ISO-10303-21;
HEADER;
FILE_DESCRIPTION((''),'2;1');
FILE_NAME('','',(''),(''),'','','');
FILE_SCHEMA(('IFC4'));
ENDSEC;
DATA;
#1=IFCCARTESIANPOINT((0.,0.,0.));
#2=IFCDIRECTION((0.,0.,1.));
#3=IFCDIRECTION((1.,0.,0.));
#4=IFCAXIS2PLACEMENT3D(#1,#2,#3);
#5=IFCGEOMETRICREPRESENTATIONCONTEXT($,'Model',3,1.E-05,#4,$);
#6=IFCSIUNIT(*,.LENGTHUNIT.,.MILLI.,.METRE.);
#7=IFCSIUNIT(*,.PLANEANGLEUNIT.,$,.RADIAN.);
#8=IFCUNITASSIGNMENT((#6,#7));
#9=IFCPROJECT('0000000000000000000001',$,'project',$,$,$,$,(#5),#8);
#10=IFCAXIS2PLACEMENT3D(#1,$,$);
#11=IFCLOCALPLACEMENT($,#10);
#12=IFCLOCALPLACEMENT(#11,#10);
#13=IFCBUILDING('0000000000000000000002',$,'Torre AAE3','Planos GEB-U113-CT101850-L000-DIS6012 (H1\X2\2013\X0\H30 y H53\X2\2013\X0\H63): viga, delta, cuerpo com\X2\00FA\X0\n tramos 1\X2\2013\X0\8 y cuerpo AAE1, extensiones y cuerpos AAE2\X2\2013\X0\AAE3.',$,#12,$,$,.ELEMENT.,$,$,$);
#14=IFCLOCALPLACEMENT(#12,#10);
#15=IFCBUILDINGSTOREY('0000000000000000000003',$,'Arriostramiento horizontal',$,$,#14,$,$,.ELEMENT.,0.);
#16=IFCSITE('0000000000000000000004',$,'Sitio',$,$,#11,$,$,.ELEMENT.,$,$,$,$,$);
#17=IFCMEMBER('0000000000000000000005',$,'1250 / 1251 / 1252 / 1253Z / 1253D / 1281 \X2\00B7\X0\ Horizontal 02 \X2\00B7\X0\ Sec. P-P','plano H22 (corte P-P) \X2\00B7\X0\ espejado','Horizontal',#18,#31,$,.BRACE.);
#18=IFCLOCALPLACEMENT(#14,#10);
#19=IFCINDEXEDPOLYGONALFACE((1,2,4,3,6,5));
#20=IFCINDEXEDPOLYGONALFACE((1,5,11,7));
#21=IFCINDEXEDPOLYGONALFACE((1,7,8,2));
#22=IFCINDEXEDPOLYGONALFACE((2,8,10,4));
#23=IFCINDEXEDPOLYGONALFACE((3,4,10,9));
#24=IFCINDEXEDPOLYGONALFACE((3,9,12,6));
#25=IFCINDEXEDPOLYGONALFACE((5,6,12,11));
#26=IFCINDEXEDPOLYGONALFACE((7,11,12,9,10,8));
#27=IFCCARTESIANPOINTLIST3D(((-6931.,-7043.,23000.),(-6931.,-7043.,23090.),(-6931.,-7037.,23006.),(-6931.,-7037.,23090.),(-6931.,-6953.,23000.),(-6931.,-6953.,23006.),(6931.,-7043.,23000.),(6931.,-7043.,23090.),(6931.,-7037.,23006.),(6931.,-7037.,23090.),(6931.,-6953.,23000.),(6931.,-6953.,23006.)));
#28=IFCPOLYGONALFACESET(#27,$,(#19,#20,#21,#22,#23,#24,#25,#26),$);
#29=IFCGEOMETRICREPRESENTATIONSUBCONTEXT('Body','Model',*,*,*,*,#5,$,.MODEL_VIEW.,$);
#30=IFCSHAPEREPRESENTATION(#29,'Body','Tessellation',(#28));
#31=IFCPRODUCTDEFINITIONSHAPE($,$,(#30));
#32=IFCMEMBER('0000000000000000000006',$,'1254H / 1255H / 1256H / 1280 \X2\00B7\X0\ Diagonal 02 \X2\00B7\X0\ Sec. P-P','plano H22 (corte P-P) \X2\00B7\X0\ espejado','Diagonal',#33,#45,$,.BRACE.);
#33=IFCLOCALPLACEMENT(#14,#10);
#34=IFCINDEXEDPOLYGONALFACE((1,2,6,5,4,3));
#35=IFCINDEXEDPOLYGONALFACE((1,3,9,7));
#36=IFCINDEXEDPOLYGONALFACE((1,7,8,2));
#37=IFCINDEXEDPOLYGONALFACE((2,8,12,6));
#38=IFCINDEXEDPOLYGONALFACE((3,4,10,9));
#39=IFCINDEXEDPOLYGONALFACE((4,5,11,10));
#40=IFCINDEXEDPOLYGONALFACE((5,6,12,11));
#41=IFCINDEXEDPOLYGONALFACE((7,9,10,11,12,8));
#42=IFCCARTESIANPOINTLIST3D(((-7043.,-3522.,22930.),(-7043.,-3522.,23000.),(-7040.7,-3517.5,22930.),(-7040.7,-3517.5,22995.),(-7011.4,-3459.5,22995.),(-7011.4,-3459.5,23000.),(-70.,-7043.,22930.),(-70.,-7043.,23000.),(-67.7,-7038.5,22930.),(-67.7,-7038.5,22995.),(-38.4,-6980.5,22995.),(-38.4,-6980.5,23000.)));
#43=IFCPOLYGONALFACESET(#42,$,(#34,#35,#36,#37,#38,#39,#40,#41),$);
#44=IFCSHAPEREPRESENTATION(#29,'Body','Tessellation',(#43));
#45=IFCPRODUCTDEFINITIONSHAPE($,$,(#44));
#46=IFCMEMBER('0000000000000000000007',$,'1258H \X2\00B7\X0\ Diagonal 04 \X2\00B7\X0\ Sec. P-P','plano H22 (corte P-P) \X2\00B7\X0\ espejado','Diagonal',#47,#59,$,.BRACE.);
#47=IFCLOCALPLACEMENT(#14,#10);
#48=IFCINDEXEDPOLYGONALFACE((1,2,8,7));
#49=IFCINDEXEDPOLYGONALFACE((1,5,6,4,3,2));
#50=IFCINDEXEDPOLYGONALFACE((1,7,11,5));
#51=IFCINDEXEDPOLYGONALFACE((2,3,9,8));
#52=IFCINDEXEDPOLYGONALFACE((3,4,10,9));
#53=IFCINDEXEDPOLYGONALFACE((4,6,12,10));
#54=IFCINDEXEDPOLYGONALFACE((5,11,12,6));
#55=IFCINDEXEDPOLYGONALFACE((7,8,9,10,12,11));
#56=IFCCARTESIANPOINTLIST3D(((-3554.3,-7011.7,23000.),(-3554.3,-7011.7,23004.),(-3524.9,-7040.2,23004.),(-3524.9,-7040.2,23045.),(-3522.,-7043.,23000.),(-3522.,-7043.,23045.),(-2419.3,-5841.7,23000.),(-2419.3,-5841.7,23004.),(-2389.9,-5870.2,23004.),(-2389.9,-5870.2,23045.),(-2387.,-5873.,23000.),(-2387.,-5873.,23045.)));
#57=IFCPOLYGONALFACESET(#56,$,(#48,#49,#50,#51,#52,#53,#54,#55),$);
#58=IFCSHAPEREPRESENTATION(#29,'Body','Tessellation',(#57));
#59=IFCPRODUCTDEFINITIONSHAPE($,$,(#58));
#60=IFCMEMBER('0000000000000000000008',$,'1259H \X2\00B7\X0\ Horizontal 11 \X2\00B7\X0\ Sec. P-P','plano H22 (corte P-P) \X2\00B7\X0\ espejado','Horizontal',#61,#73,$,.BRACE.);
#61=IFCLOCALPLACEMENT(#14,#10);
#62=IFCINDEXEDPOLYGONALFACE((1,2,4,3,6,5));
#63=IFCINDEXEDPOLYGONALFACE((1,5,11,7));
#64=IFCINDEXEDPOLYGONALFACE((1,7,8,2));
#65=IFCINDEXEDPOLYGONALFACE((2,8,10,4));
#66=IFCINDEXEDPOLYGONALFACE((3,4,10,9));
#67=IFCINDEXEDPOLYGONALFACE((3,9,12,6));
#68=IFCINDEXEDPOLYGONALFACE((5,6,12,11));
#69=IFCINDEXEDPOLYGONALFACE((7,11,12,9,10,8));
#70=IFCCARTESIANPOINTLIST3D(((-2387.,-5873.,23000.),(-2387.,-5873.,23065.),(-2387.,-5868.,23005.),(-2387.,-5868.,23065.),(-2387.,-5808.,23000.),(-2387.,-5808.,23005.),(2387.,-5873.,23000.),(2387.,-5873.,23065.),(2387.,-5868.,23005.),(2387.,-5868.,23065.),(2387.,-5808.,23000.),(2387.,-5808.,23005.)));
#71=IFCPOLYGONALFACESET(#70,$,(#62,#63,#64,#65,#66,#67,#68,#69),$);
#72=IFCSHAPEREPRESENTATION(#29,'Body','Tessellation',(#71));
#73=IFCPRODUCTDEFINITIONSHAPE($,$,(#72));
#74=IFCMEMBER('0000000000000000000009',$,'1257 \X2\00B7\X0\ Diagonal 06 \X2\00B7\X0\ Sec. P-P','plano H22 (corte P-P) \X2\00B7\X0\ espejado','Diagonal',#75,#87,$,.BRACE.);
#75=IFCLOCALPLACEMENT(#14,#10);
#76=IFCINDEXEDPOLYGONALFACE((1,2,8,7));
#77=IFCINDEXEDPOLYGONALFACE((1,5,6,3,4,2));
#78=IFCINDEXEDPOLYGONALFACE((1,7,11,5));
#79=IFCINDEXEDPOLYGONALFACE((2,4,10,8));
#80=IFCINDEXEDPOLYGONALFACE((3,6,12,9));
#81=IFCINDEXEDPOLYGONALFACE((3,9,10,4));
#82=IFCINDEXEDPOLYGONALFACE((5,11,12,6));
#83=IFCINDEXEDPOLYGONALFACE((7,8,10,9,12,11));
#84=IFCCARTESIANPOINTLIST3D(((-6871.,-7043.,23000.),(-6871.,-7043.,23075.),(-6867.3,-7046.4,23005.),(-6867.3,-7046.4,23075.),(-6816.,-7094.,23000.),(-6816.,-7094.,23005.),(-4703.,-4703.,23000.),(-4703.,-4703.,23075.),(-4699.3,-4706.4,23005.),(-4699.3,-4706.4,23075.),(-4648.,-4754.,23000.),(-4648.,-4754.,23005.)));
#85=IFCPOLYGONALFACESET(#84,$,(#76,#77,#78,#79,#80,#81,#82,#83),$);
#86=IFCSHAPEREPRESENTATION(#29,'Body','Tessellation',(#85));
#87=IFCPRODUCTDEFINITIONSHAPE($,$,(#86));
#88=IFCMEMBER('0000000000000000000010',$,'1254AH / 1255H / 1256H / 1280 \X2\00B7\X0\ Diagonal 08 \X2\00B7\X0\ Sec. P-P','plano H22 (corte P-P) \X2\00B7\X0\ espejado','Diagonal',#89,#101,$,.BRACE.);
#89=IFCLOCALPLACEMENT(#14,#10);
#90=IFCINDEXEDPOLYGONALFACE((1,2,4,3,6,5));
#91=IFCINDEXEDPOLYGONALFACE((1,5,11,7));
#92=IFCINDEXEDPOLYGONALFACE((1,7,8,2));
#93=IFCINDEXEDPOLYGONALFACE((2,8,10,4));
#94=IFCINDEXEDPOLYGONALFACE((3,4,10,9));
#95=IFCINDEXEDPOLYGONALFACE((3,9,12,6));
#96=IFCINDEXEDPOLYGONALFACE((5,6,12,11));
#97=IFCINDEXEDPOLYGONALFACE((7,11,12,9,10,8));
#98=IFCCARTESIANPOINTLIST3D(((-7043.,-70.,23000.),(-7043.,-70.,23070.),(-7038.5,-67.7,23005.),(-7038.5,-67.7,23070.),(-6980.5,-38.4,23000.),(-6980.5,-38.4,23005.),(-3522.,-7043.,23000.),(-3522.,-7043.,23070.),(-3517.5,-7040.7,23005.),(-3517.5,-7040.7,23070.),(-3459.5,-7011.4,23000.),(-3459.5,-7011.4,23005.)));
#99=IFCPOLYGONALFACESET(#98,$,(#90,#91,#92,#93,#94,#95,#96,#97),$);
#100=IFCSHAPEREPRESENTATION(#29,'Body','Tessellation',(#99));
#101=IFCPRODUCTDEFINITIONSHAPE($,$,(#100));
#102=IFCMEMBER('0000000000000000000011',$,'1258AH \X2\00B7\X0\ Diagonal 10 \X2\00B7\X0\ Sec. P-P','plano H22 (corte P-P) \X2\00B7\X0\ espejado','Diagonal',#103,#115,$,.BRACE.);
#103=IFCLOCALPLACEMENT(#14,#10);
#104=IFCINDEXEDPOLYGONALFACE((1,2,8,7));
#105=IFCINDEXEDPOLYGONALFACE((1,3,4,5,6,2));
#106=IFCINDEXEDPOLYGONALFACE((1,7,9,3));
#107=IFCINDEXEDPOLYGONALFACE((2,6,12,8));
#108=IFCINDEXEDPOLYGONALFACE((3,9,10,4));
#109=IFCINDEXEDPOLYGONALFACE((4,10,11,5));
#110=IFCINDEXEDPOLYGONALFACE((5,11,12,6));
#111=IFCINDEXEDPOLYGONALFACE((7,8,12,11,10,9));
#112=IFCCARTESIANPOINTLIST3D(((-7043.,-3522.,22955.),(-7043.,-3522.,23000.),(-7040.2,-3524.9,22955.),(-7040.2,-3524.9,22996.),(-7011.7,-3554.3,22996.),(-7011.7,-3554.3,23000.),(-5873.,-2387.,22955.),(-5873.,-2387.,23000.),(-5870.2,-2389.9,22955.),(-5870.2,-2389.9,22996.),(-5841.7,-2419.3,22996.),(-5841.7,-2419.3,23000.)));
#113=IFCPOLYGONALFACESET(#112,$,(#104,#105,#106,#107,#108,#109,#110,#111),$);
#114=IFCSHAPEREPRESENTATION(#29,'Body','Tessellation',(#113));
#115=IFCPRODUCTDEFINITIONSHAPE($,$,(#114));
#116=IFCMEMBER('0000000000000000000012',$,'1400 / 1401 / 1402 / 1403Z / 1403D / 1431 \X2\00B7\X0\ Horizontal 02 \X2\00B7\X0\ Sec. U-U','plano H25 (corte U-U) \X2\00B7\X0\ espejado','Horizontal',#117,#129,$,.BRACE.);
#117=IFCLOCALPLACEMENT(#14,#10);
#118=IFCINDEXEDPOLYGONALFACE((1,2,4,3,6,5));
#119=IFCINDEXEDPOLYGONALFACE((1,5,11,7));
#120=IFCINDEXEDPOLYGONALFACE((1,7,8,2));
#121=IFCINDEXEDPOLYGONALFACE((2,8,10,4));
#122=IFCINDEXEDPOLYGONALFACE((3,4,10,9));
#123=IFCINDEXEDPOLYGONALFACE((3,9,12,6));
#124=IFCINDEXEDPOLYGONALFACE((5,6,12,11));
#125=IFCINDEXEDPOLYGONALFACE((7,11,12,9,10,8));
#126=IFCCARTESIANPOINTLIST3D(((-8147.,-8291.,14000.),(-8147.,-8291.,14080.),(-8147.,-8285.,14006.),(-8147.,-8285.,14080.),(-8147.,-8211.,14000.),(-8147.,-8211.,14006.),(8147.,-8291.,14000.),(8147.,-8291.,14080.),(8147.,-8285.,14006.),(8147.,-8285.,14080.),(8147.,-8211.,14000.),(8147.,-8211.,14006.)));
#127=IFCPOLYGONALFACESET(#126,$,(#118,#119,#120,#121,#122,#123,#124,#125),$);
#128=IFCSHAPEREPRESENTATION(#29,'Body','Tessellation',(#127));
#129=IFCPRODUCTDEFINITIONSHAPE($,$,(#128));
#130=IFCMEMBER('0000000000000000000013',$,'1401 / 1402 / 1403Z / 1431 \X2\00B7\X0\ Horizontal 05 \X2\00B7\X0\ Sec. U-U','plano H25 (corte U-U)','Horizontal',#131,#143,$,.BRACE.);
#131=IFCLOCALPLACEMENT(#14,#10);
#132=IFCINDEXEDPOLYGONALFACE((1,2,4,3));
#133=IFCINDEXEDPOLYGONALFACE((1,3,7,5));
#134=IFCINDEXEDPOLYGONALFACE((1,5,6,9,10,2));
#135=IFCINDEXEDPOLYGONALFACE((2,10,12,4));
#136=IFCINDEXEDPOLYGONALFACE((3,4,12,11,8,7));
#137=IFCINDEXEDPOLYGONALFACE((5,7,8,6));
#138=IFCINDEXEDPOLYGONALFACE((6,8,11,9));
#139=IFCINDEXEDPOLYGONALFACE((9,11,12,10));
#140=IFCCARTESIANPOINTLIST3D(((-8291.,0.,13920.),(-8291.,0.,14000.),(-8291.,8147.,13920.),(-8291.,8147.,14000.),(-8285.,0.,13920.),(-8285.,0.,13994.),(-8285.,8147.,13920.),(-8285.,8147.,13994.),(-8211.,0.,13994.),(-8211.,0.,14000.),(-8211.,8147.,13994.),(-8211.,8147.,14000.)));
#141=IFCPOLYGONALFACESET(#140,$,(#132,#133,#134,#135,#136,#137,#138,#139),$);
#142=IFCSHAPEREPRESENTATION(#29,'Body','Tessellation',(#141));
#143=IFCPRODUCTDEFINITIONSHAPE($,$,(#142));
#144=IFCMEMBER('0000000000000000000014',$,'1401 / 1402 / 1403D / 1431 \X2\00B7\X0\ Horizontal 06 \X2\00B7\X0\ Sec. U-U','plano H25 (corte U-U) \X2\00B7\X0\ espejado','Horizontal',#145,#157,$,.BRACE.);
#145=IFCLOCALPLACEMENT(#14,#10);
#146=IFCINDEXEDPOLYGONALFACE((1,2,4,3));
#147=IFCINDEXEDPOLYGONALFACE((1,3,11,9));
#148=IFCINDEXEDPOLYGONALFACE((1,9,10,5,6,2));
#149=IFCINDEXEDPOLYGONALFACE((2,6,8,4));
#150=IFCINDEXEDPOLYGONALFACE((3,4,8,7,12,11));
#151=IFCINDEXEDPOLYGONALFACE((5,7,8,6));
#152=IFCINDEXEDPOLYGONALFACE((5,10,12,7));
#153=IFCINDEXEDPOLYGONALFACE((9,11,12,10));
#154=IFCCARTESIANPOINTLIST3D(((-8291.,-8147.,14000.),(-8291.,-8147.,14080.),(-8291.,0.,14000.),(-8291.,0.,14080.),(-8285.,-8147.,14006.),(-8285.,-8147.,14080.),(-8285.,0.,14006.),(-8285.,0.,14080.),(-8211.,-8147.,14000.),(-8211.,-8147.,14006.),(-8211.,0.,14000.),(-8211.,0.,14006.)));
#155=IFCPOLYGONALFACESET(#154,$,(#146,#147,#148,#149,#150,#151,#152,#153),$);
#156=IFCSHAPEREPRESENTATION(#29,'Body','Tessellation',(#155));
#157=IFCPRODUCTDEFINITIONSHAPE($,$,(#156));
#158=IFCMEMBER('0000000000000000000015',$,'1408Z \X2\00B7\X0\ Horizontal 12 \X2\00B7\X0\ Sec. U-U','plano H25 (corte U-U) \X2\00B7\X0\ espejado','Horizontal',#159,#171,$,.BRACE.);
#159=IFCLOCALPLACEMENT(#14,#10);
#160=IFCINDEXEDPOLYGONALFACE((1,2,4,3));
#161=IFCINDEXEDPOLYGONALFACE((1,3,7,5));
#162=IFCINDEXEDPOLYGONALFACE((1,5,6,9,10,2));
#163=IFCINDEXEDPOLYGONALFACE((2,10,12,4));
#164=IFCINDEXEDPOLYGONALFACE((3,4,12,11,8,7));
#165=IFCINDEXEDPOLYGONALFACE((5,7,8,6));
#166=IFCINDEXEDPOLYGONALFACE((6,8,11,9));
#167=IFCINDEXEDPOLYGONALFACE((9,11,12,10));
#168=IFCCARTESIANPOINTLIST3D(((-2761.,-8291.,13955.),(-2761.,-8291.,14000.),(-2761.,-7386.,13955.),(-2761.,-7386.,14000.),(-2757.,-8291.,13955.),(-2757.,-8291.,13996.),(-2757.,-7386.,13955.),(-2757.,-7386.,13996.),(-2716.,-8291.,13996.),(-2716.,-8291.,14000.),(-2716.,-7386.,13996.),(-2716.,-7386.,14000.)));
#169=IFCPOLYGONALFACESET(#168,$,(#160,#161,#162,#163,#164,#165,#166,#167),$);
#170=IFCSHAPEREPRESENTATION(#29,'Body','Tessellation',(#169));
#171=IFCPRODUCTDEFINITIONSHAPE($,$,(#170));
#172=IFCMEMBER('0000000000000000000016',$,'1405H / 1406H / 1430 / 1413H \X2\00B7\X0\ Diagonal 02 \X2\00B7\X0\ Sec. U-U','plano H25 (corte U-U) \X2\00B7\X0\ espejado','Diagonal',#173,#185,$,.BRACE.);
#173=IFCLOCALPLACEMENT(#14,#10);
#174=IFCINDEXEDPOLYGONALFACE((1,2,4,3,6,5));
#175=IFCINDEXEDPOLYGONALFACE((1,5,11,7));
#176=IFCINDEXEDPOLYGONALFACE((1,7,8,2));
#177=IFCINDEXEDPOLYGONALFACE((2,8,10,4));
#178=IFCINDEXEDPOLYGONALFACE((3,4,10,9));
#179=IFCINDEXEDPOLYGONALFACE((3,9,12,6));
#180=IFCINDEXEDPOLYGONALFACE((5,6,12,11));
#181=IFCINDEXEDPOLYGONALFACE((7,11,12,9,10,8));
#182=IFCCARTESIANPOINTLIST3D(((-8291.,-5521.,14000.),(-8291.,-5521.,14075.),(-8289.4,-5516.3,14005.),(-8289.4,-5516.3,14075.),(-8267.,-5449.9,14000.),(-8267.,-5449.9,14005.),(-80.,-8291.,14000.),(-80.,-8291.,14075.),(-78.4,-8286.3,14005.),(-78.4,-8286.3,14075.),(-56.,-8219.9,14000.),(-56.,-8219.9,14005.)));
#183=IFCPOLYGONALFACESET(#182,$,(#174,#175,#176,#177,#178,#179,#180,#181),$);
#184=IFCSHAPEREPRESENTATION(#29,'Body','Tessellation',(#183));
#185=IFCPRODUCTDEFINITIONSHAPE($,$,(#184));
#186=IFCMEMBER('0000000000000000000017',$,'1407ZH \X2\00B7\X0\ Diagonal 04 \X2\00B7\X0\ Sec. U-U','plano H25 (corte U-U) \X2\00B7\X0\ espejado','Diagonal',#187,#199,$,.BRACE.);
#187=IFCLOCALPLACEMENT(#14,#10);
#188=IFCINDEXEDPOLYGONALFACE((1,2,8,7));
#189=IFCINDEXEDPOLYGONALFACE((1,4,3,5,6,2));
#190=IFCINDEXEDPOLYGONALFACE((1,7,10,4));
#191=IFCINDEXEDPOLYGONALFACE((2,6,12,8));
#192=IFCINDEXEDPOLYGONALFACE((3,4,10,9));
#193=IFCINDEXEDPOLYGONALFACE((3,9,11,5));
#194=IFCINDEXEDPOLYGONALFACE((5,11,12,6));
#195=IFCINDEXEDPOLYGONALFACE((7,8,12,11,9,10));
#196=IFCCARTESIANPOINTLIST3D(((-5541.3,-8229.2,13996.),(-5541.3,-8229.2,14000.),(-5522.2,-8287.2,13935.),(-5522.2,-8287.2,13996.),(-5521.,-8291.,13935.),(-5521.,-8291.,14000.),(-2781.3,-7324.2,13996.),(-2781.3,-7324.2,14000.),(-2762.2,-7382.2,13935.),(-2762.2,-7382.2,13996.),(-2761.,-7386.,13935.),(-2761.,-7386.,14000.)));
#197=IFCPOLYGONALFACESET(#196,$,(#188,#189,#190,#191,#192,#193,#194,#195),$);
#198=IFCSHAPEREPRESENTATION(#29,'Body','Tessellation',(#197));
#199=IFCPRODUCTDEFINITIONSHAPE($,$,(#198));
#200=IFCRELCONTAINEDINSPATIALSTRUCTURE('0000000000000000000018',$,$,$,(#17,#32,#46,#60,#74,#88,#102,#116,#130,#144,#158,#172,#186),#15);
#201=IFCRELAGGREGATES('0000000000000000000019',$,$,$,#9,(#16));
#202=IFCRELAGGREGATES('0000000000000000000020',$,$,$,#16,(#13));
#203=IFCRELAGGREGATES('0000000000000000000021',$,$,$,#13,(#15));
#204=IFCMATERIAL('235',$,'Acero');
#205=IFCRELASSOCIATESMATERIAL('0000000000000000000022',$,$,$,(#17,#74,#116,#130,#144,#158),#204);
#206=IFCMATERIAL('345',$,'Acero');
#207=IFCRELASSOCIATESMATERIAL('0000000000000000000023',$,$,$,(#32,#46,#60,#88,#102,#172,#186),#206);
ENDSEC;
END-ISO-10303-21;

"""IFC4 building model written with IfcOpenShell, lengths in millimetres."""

from ifc_helpers import new_model, si_unit, frame, frame_2d, origin, origin_with_axes, place, context, subcontext, project, spatial, l_section, extrude, material, element, save


model = new_model("IFC4")

# Units and contexts
model_context = context("Model", 3, precision=1e-05, world=origin_with_axes())
body_context = subcontext(model_context, "Body", "Model", "MODEL_VIEW")
ifc_project = project(units=[si_unit("LENGTHUNIT", "METRE", prefix="MILLI"), si_unit("PLANEANGLEUNIT", "RADIAN")], contexts=[model_context])

# Site, building, storey
site_placement = place(None, origin())
site = spatial("IfcSite", under=ifc_project, at=site_placement, Name="Sitio", CompositionType="ELEMENT")
building_placement = place(site_placement, origin())
building = spatial("IfcBuilding", under=site, at=building_placement, Name="Torre AAE3", Description="Planos GEB-U113-CT101850-L000-DIS6012 (H1–H30 y H53–H63): viga, delta, cuerpo común tramos 1–8 y cuerpo AAE1, extensiones y cuerpos AAE2–AAE3.", CompositionType="ELEMENT")
storey_placement = place(building_placement, origin())
storey = spatial("IfcBuildingStorey", under=building, at=storey_placement, Name="Arriostramiento horizontal", CompositionType="ELEMENT", Elevation=0.0)

# Members
ifc_material_1 = material(Name="235", Category="Acero")
member_1_placement = place(storey_placement, frame((-6931.0, -7043.0, 23000.0), z_axis=(1.0, 0.0, 0.0), x_axis=(0.0, 1.0, 0.0)))
element("IfcMember", 1, at=member_1_placement, inside=storey, material=ifc_material_1, Name="1250 / 1251 / 1252 / 1253Z / 1253D / 1281 · Horizontal 02 · Sec. P-P", Description="plano H22 (corte P-P) · espejado", ObjectType="Horizontal", PredefinedType="BRACE", context=body_context, shape_type="SweptSolid", body=[
    extrude(l_section(Depth=90.0, Width=90.0, Thickness=6.0, at=frame_2d((45.0, 45.0))), None, (0.0, 0.0, 1.0), 13862.0),
])
ifc_material_2 = material(Name="345", Category="Acero")
member_2_placement = place(storey_placement, frame((-70.0, -7043.0, 23000.0), z_axis=(-0.892654, 0.450743, 0.0), x_axis=(0.450743, 0.892654, 0.0)))
element("IfcMember", 2, at=member_2_placement, inside=storey, material=ifc_material_2, Name="1254H / 1255H / 1256H / 1280 · Diagonal 02 · Sec. P-P", Description="plano H22 (corte P-P) · espejado", ObjectType="Diagonal", PredefinedType="BRACE", context=body_context, shape_type="SweptSolid", body=[
    extrude(l_section(Depth=70.0, Width=70.0, Thickness=5.0, at=frame_2d((35.0, 35.0))), None, (0.0, 0.0, 1.0), 7811.5),
])
member_3_placement = place(storey_placement, frame((-3522.0, -7043.0, 23000.0), z_axis=(0.69629, 0.717761, 0.0), x_axis=(-0.717761, 0.69629, 0.0)))
element("IfcMember", 3, at=member_3_placement, inside=storey, material=ifc_material_2, Name="1258H · Diagonal 04 · Sec. P-P", Description="plano H22 (corte P-P) · espejado", ObjectType="Diagonal", PredefinedType="BRACE", context=body_context, shape_type="SweptSolid", body=[
    extrude(l_section(Depth=45.0, Width=45.0, Thickness=4.0, at=frame_2d((22.5, 22.5))), None, (0.0, 0.0, 1.0), 1630.1),
])
member_4_placement = place(storey_placement, frame((-2387.0, -5873.0, 23000.0), z_axis=(1.0, 0.0, 0.0), x_axis=(0.0, 1.0, 0.0)))
element("IfcMember", 4, at=member_4_placement, inside=storey, material=ifc_material_2, Name="1259H · Horizontal 11 · Sec. P-P", Description="plano H22 (corte P-P) · espejado", ObjectType="Horizontal", PredefinedType="BRACE", context=body_context, shape_type="SweptSolid", body=[
    extrude(l_section(Depth=65.0, Width=65.0, Thickness=5.0, at=frame_2d((32.5, 32.5))), None, (0.0, 0.0, 1.0), 4774.0),
])
member_5_placement = place(storey_placement, frame((-4703.0, -4703.0, 23000.0), z_axis=(-0.679633, -0.733552, 0.0), x_axis=(0.733552, -0.679633, 0.0)))
element("IfcMember", 5, at=member_5_placement, inside=storey, material=ifc_material_1, Name="1257 · Diagonal 06 · Sec. P-P", Description="plano H22 (corte P-P) · espejado", ObjectType="Diagonal", PredefinedType="BRACE", context=body_context, shape_type="SweptSolid", body=[
    extrude(l_section(Depth=75.0, Width=75.0, Thickness=5.0, at=frame_2d((37.5, 37.5))), None, (0.0, 0.0, 1.0), 3190.0),
])
member_6_placement = place(storey_placement, frame((-7043.0, -70.0, 23000.0), z_axis=(0.450743, -0.892654, 0.0), x_axis=(0.892654, 0.450743, 0.0)))
element("IfcMember", 6, at=member_6_placement, inside=storey, material=ifc_material_2, Name="1254AH / 1255H / 1256H / 1280 · Diagonal 08 · Sec. P-P", Description="plano H22 (corte P-P) · espejado", ObjectType="Diagonal", PredefinedType="BRACE", context=body_context, shape_type="SweptSolid", body=[
    extrude(l_section(Depth=70.0, Width=70.0, Thickness=5.0, at=frame_2d((35.0, 35.0))), None, (0.0, 0.0, 1.0), 7811.5),
])
member_7_placement = place(storey_placement, frame((-7043.0, -3522.0, 23000.0), z_axis=(0.717761, 0.69629, 0.0), x_axis=(0.69629, -0.717761, 0.0)))
element("IfcMember", 7, at=member_7_placement, inside=storey, material=ifc_material_2, Name="1258AH · Diagonal 10 · Sec. P-P", Description="plano H22 (corte P-P) · espejado", ObjectType="Diagonal", PredefinedType="BRACE", context=body_context, shape_type="SweptSolid", body=[
    extrude(l_section(Depth=45.0, Width=45.0, Thickness=4.0, at=frame_2d((22.5, 22.5))), None, (0.0, 0.0, 1.0), 1630.1),
])
member_8_placement = place(storey_placement, frame((-8147.0, -8291.0, 14000.0), z_axis=(1.0, 0.0, 0.0), x_axis=(0.0, 1.0, 0.0)))
element("IfcMember", 8, at=member_8_placement, inside=storey, material=ifc_material_1, Name="1400 / 1401 / 1402 / 1403Z / 1403D / 1431 · Horizontal 02 · Sec. U-U", Description="plano H25 (corte U-U) · espejado", ObjectType="Horizontal", PredefinedType="BRACE", context=body_context, shape_type="SweptSolid", body=[
    extrude(l_section(Depth=80.0, Width=80.0, Thickness=6.0, at=frame_2d((40.0, 40.0))), None, (0.0, 0.0, 1.0), 16294.0),
])
for number, where, z_axis, x_axis, name, description in (
    (9, (-8291.0, 0.0, 14000.0), (0.0, 1.0, 0.0), (1.0, 0.0, 0.0), "1401 / 1402 / 1403Z / 1431 · Horizontal 05 · Sec. U-U", "plano H25 (corte U-U)"),
    (10, (-8291.0, 0.0, 14000.0), (0.0, -1.0, 0.0), (1.0, 0.0, 0.0), "1401 / 1402 / 1403D / 1431 · Horizontal 06 · Sec. U-U", "plano H25 (corte U-U) · espejado"),
):
    element("IfcMember", number, at=place(storey_placement, frame(where, z_axis=z_axis, x_axis=x_axis)), inside=storey, material=ifc_material_1, Name=name, Description=description, ObjectType="Horizontal", PredefinedType="BRACE", context=body_context, shape_type="SweptSolid", body=[
        extrude(l_section(Depth=80.0, Width=80.0, Thickness=6.0, at=frame_2d((40.0, 40.0))), None, (0.0, 0.0, 1.0), 8147.0),
    ])
member_9_placement = place(storey_placement, frame((-2761.0, -8291.0, 14000.0), z_axis=(0.0, 1.0, 0.0), x_axis=(1.0, 0.0, 0.0)))
element("IfcMember", 11, at=member_9_placement, inside=storey, material=ifc_material_1, Name="1408Z · Horizontal 12 · Sec. U-U", Description="plano H25 (corte U-U) · espejado", ObjectType="Horizontal", PredefinedType="BRACE", context=body_context, shape_type="SweptSolid", body=[
    extrude(l_section(Depth=45.0, Width=45.0, Thickness=4.0, at=frame_2d((22.5, 22.5))), None, (0.0, 0.0, 1.0), 905.0),
])
member_10_placement = place(storey_placement, frame((-8291.0, -5521.0, 14000.0), z_axis=(0.947535, -0.319653, 0.0), x_axis=(0.319653, 0.947535, 0.0)))
element("IfcMember", 12, at=member_10_placement, inside=storey, material=ifc_material_2, Name="1405H / 1406H / 1430 / 1413H · Diagonal 02 · Sec. U-U", Description="plano H25 (corte U-U) · espejado", ObjectType="Diagonal", PredefinedType="BRACE", context=body_context, shape_type="SweptSolid", body=[
    extrude(l_section(Depth=75.0, Width=75.0, Thickness=5.0, at=frame_2d((37.5, 37.5))), None, (0.0, 0.0, 1.0), 8665.6),
])
member_11_placement = place(storey_placement, frame((-2761.0, -7386.0, 14000.0), z_axis=(-0.950221, -0.311576, 0.0), x_axis=(-0.311576, 0.950221, 0.0)))
element("IfcMember", 13, at=member_11_placement, inside=storey, material=ifc_material_2, Name="1407ZH · Diagonal 04 · Sec. U-U", Description="plano H25 (corte U-U) · espejado", ObjectType="Diagonal", PredefinedType="BRACE", context=body_context, shape_type="SweptSolid", body=[
    extrude(l_section(Depth=65.0, Width=65.0, Thickness=4.0, at=frame_2d((32.5, 32.5))), None, (0.0, 0.0, 1.0), 2904.6),
])

save(model, "model.ifc")
